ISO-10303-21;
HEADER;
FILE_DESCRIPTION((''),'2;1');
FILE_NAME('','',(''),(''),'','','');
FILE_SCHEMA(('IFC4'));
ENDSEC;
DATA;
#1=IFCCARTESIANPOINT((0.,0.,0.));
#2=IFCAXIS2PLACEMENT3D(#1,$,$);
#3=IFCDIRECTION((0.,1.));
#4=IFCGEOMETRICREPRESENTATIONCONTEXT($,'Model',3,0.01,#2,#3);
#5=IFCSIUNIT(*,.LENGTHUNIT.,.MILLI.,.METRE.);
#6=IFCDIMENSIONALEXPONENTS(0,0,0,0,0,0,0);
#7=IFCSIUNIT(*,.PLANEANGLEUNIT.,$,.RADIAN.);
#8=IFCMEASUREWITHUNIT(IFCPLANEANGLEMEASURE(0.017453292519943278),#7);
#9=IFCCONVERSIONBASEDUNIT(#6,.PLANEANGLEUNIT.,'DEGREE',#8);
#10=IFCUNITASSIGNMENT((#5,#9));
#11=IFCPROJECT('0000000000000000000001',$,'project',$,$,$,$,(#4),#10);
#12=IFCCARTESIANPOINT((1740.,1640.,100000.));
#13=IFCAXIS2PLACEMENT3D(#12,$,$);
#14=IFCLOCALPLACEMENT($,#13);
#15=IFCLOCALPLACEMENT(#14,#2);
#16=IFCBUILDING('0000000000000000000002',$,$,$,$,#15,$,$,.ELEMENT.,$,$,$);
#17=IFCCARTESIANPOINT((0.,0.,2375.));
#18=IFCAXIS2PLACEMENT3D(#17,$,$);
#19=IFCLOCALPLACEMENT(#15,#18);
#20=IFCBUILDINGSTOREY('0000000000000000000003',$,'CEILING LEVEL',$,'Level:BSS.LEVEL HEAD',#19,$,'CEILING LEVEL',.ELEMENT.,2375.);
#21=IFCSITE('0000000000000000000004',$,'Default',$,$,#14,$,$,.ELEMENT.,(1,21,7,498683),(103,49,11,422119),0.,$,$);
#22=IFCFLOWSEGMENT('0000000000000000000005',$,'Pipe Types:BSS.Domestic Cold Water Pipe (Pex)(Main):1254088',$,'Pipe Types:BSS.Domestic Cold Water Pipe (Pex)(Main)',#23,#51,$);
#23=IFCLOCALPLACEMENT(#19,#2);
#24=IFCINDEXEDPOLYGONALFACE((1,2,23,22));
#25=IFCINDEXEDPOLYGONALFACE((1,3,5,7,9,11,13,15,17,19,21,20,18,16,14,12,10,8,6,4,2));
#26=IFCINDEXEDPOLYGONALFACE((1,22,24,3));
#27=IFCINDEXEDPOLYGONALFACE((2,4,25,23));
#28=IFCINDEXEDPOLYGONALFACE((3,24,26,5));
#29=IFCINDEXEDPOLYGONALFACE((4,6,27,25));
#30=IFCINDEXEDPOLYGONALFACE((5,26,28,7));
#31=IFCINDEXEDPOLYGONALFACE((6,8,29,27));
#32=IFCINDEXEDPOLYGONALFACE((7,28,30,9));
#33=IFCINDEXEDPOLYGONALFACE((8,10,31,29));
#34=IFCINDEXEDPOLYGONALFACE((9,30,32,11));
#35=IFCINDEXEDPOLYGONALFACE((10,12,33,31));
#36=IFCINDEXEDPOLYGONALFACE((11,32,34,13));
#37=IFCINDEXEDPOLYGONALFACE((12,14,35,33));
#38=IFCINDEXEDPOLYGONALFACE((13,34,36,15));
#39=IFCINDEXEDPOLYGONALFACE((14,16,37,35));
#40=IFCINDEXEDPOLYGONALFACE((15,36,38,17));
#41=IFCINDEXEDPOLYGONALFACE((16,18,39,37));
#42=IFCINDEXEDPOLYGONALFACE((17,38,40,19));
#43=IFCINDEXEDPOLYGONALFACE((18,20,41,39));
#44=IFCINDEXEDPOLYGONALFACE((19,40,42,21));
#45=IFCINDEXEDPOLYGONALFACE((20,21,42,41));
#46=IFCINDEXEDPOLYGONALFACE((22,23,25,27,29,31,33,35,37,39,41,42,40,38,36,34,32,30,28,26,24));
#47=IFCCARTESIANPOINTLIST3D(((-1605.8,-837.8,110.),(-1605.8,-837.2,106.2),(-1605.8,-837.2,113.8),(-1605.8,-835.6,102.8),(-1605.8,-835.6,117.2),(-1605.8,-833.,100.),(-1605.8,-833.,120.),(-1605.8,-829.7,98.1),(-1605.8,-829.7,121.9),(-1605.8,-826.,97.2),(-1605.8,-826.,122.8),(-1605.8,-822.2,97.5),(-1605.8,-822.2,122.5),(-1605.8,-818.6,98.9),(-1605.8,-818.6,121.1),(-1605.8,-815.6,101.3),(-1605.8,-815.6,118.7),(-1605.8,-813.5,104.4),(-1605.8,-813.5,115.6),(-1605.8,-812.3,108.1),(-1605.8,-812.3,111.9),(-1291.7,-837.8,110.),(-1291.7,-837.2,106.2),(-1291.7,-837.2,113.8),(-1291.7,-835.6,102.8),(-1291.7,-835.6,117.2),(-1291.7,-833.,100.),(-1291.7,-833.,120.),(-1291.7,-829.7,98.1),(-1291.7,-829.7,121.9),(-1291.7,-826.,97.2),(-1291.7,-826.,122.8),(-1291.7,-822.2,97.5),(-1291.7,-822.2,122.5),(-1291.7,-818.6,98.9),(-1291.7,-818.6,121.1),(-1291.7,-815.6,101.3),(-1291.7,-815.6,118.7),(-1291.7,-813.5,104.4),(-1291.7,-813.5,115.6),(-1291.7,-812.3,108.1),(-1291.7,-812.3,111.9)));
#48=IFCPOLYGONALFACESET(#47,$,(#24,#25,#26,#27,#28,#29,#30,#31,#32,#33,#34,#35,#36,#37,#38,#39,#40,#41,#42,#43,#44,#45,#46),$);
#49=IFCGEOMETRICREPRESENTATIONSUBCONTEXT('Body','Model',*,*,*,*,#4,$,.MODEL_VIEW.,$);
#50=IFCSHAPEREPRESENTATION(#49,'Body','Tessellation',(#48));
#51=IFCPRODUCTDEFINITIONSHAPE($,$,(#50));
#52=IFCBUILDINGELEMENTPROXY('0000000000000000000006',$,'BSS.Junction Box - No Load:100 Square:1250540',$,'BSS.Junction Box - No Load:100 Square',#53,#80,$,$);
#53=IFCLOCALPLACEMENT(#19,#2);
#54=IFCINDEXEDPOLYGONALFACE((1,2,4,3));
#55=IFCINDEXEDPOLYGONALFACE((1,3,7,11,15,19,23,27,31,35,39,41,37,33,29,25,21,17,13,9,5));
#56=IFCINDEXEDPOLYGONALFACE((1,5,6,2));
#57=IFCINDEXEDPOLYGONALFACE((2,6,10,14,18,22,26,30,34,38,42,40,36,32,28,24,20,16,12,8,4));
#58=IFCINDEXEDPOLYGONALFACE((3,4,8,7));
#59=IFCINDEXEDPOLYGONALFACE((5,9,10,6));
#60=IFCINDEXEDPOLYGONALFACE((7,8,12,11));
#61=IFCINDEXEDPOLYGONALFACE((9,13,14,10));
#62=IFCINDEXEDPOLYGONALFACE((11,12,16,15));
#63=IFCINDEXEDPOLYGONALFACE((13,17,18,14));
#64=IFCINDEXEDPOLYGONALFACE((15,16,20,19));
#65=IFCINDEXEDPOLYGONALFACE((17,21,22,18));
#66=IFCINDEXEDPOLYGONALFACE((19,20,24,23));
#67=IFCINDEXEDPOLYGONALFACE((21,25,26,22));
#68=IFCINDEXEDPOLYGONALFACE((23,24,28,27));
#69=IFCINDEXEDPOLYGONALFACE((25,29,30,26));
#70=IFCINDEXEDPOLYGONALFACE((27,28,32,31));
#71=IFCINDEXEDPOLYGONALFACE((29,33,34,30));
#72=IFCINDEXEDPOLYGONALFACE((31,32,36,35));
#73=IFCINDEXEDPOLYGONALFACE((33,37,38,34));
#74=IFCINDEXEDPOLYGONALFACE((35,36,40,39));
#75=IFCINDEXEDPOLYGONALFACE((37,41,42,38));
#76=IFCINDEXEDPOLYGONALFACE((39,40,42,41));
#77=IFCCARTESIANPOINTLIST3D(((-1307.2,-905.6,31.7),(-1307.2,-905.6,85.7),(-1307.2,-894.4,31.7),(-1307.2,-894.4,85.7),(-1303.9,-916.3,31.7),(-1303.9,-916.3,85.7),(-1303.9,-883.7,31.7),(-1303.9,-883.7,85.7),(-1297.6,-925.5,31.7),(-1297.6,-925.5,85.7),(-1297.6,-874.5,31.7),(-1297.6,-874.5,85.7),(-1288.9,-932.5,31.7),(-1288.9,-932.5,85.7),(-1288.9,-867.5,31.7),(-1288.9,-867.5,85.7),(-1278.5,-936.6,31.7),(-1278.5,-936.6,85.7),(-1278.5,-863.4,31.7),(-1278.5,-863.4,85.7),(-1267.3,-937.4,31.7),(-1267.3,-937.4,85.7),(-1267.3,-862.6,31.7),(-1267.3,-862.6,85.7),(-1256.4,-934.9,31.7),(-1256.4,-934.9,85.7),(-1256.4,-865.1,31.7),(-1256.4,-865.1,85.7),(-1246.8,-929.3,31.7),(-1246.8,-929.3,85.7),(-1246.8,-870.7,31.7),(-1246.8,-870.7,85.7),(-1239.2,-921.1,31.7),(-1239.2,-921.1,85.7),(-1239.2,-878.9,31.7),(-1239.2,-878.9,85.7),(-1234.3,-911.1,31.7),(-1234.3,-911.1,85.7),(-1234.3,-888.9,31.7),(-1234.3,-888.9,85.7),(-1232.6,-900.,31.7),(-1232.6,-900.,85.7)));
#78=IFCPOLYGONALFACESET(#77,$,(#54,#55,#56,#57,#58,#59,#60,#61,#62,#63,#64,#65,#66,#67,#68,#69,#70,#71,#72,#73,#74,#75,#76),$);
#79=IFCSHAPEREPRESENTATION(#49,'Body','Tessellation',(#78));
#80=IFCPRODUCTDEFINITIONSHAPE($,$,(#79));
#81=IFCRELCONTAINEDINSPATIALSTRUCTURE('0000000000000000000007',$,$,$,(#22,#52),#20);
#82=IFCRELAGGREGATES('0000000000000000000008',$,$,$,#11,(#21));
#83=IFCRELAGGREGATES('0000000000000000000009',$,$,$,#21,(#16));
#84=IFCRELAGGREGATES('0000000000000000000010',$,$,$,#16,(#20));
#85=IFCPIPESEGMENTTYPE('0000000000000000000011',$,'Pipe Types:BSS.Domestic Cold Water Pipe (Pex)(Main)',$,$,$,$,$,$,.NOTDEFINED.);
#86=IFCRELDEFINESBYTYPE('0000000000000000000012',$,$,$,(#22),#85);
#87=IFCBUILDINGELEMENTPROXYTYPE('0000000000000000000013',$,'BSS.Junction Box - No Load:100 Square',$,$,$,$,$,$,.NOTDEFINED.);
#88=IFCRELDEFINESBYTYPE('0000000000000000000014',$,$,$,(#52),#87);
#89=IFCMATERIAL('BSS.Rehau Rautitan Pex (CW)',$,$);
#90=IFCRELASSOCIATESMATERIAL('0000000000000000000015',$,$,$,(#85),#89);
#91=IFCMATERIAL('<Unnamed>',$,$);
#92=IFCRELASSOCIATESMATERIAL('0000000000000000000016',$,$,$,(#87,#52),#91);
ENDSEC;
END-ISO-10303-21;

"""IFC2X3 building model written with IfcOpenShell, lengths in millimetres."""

from ifc_helpers import new_model, entity, si_unit, converted_unit, direction, frame, frame_2d, origin, place, context, subcontext, project, spatial, circle, extrude, source, transform, mapped, material, type_object, type_shapes, element, save


model = new_model("IFC2X3")

# Units and contexts
model_context = context("Model", 3, precision=0.01, world=origin(), true_north=direction((0.0, 1.0)))
body_context = subcontext(model_context, "Body", "Model", "MODEL_VIEW")
ifc_project = project(units=[si_unit("LENGTHUNIT", "METRE", prefix="MILLI"), converted_unit("PLANEANGLEUNIT", "DEGREE", entity("IfcPlaneAngleMeasure", 0.017453292519943278), si_unit("PLANEANGLEUNIT", "RADIAN"), dimensions=[0, 0, 0, 0, 0, 0, 0])], contexts=[model_context])

# Site, building, storey
site_placement = place(None, frame((1740.0, 1640.0, 100000.0)))
site = spatial("IfcSite", under=ifc_project, at=site_placement, Name="Default", CompositionType="ELEMENT", RefLatitude=(1, 21, 7, 498683), RefLongitude=(103, 49, 11, 422119), RefElevation=0.0)
building_placement = place(site_placement, origin())
building = spatial("IfcBuilding", under=site, at=building_placement, CompositionType="ELEMENT")
storey_placement = place(building_placement, frame((0.0, 0.0, 2375.0)))
storey = spatial("IfcBuildingStorey", under=building, at=storey_placement, Name="CEILING LEVEL", ObjectType="Level:BSS.LEVEL HEAD", LongName="CEILING LEVEL", CompositionType="ELEMENT", Elevation=2375.0)

# Flow segment
ifc_material_1 = material(Name="BSS.Rehau Rautitan Pex (CW)")
pipe_segment_type_1 = type_object("IfcPipeSegmentType", Name="Pipe Types:BSS.Domestic Cold Water Pipe (Pex)(Main)", PredefinedType="NOTDEFINED", material=ifc_material_1)
flow_segment_1_placement = place(storey_placement, origin())
element("IfcFlowSegment", 1, at=flow_segment_1_placement, inside=storey, type_object=pipe_segment_type_1, Name="Pipe Types:BSS.Domestic Cold Water Pipe (Pex)(Main):1254088", ObjectType="Pipe Types:BSS.Domestic Cold Water Pipe (Pex)(Main)", context=body_context, shape_type="SweptSolid", body=[
    extrude(circle(Radius=12.8, at=frame_2d((0.0, 0.0), x_axis=(1.0, 0.0))), frame((-1605.8, -825.0, 110.0), z_axis=(1.0, 0.0, 0.0), x_axis=(0.0, -1.0, 0.0)), (0.0, 0.0, 1.0), 314.1),
])

# Building element proxy
ifc_material_2 = material(Name="<Unnamed>")
building_element_proxy_type = type_object("IfcBuildingElementProxyType", Name="BSS.Junction Box - No Load:100 Square", PredefinedType="NOTDEFINED", material=ifc_material_2)
shared_shape = source(origin(), body_context, "Body", "SweptSolid", [
    extrude(circle(Radius=37.5, at=frame_2d((0.0, 0.0), x_axis=(1.0, 0.0))), origin(), (0.0, 0.0, 1.0), 54.0),
])
type_shapes(building_element_proxy_type, [shared_shape])
proxy_placement = place(storey_placement, frame((-1270.1, -900.0, 31.7)))
element("IfcBuildingElementProxy", 2, at=proxy_placement, inside=storey, type_object=building_element_proxy_type, material=ifc_material_2, Name="BSS.Junction Box - No Load:100 Square:1250540", ObjectType="BSS.Junction Box - No Load:100 Square", context=body_context, shape_type="MappedRepresentation", body=[
    mapped(shared_shape, transform((0.0, 0.0, 0.0), scale=1.0)),
])

save(model, "model.ifc")
